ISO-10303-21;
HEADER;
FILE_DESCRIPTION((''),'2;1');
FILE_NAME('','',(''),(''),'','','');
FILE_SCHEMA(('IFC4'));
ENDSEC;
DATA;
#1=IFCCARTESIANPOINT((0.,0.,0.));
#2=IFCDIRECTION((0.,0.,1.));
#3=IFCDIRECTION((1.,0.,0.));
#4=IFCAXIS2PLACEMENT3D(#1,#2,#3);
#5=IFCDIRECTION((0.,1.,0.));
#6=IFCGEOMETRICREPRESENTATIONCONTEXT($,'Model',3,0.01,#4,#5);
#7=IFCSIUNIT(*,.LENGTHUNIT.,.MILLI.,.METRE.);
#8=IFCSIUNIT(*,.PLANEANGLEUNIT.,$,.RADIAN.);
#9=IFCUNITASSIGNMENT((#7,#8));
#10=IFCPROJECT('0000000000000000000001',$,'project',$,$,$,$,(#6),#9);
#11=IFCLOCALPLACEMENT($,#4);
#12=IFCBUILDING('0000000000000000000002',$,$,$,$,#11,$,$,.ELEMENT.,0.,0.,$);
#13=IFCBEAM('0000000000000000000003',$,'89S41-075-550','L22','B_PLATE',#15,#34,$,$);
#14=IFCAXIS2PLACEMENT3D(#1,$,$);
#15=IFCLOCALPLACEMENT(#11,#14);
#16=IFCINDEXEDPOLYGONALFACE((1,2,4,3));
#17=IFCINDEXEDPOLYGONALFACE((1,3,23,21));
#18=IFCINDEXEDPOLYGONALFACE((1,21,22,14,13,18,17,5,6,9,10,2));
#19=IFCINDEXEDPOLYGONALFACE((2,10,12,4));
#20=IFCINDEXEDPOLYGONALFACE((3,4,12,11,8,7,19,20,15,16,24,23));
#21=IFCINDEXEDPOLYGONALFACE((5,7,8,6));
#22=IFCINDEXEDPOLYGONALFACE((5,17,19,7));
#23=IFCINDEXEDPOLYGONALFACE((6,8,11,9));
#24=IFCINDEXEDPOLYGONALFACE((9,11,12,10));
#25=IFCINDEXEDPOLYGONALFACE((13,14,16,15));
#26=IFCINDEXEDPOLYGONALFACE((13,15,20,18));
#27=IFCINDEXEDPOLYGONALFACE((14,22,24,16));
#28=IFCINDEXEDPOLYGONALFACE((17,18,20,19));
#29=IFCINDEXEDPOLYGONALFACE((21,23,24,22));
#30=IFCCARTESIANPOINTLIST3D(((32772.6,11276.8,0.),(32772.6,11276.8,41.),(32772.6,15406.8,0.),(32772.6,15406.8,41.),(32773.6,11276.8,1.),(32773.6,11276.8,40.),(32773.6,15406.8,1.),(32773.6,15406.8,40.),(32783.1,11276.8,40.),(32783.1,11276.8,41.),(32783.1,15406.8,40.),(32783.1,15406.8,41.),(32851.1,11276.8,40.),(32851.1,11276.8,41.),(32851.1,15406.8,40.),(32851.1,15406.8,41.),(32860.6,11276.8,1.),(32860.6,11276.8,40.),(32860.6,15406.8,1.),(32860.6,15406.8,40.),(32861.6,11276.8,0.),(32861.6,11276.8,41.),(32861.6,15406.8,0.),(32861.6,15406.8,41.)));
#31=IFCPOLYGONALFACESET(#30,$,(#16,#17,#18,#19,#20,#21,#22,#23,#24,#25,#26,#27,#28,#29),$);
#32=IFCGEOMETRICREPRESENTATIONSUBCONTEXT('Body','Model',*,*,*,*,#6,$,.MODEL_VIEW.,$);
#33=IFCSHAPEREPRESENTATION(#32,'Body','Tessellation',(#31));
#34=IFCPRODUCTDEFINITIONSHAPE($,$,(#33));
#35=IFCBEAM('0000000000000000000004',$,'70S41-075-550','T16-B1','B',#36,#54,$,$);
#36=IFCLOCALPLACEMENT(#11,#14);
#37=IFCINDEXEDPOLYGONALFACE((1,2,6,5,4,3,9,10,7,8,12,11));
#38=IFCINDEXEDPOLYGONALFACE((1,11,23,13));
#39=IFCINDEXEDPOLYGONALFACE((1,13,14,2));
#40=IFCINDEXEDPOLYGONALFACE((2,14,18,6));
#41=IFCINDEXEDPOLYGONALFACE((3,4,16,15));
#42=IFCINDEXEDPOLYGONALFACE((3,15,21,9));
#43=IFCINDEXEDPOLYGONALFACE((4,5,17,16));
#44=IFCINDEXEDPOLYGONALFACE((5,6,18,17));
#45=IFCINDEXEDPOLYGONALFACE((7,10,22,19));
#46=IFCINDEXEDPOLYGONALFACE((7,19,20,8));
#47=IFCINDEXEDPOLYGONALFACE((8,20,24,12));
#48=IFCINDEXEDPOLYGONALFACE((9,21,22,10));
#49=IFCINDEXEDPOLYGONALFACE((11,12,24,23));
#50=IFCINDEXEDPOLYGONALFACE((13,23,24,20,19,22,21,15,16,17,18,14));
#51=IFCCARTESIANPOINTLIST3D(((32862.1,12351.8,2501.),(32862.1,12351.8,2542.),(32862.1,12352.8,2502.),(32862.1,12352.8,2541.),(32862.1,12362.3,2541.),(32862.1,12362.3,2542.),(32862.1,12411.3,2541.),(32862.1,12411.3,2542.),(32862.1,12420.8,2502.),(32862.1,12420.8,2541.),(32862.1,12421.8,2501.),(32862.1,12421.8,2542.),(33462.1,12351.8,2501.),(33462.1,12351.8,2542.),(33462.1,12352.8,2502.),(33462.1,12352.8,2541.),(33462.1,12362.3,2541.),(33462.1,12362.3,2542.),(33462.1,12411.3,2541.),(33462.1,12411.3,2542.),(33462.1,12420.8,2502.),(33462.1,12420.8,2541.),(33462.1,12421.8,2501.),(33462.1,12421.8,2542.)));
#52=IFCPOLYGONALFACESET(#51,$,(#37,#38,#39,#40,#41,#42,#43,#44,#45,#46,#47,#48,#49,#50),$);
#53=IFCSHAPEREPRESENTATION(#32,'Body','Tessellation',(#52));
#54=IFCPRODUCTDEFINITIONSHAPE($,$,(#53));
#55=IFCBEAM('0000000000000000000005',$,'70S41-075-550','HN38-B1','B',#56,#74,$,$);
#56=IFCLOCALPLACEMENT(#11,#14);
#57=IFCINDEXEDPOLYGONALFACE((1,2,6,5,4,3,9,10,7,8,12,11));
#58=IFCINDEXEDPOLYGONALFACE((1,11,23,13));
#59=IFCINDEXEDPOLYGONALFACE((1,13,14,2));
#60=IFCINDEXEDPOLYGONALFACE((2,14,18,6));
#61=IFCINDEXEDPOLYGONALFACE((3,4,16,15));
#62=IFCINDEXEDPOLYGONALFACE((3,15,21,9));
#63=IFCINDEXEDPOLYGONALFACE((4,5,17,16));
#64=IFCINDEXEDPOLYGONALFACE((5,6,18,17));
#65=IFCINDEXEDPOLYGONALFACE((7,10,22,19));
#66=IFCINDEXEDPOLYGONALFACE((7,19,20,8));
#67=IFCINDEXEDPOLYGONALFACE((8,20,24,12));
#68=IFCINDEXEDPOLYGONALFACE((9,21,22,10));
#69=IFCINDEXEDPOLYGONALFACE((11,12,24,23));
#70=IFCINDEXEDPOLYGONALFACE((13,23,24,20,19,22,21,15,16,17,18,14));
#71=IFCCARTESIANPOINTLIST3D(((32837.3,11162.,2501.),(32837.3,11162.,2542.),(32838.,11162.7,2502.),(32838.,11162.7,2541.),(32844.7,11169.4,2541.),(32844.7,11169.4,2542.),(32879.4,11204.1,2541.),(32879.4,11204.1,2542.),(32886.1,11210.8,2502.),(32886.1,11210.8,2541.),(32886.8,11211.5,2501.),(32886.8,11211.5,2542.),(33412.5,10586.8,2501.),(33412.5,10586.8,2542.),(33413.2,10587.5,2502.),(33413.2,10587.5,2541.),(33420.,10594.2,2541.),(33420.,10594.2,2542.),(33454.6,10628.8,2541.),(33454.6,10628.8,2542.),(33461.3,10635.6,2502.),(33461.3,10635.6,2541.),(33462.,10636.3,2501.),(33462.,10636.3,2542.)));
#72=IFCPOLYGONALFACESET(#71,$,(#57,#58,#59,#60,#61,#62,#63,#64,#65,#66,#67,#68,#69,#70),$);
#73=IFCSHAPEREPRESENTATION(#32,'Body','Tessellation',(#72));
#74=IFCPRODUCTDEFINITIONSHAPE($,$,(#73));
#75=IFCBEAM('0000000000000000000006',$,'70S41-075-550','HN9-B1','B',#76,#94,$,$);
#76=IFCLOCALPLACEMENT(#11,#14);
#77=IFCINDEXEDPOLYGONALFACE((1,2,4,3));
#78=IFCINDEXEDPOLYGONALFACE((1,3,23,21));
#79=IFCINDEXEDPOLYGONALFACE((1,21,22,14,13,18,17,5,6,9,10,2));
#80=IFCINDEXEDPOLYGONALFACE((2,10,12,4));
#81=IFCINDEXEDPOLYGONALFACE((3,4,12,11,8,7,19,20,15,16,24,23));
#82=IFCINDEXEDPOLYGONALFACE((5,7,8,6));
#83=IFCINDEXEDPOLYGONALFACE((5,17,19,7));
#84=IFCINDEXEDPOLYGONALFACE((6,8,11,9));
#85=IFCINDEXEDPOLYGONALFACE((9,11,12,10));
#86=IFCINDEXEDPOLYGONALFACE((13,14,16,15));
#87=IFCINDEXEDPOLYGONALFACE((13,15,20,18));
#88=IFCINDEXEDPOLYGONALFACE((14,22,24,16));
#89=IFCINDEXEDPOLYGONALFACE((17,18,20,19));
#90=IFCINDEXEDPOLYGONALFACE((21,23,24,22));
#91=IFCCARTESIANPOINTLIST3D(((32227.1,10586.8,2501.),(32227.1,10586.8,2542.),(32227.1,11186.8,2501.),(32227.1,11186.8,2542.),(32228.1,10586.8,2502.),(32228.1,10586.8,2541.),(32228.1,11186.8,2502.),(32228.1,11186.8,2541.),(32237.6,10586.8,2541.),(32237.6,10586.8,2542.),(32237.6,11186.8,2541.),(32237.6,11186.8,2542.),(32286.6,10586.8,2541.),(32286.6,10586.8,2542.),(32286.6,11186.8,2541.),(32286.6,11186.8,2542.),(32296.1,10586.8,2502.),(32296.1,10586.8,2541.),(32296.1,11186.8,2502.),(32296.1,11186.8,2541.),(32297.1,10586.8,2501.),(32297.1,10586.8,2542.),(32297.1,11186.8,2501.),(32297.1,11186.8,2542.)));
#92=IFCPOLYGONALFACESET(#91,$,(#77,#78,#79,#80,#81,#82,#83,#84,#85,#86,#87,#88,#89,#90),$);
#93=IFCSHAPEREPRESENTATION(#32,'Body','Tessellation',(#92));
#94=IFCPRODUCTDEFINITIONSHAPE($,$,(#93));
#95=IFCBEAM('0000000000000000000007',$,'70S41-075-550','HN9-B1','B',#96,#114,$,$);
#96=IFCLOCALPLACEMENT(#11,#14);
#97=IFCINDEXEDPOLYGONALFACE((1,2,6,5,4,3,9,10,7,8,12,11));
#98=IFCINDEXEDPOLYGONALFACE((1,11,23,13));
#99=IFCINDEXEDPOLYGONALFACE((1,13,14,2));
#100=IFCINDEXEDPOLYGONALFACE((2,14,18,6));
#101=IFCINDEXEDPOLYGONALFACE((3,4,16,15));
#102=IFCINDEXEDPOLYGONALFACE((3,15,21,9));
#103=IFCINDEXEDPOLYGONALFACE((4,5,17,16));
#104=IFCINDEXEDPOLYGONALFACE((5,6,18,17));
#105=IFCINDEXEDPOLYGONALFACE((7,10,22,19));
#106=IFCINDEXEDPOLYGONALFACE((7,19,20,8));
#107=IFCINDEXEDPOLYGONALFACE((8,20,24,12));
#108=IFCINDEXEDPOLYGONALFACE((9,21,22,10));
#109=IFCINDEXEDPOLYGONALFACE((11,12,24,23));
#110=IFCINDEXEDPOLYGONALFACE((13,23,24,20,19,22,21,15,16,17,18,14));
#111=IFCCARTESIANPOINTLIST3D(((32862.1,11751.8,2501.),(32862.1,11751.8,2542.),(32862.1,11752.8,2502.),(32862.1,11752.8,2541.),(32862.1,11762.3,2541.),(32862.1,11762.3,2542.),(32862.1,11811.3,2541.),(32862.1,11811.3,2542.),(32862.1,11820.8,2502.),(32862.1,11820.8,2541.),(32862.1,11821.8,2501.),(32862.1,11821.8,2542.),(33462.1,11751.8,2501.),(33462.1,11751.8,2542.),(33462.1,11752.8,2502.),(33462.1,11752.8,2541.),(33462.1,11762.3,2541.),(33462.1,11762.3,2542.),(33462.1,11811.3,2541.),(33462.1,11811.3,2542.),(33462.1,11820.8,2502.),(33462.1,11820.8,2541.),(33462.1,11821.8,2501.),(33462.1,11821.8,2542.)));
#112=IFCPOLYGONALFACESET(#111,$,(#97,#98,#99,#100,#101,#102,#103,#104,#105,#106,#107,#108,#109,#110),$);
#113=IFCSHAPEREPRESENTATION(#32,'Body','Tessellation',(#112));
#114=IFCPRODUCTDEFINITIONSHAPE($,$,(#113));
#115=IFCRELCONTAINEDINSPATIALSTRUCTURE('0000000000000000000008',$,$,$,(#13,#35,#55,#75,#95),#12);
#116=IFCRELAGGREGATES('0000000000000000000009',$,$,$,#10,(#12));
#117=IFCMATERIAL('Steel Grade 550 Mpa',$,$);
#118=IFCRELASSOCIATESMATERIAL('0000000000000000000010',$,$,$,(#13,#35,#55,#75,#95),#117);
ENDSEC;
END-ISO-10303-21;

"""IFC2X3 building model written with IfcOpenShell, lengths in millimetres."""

from ifc_helpers import new_model, si_unit, direction, frame, origin, origin_with_axes, origin_2d_with_axis, place, context, subcontext, project, spatial, c_section, extrude, source, transform, mapped, material, element, save


model = new_model("IFC2X3")

# Units and contexts
model_context = context("Model", 3, precision=0.01, world=origin_with_axes(), true_north=direction((0.0, 1.0, 0.0)))
body_context = subcontext(model_context, "Body", "Model", "MODEL_VIEW")
ifc_project = project(units=[si_unit("LENGTHUNIT", "METRE", prefix="MILLI"), si_unit("PLANEANGLEUNIT", "RADIAN")], contexts=[model_context])

# Building
building_placement = place(None, origin_with_axes())
building = spatial("IfcBuilding", under=ifc_project, at=building_placement, CompositionType="ELEMENT", ElevationOfRefHeight=0.0, ElevationOfTerrain=0.0)

# Shared definitions
ifc_material = material(Name="Steel Grade 550 Mpa")

# Beams
shared_shape_1 = source(origin(), body_context, "Body", "SweptSolid", [
    extrude(c_section(Depth=89.0, Width=41.0, WallThickness=1.0, Girth=10.5, at=origin_2d_with_axis()), origin_with_axes(), (0.0, 0.0, 1.0), 4130.0),
])
beam_1_placement = place(None, frame((32817.1, 11276.8, 20.5), z_axis=(0.0, 1.0, 0.0), x_axis=(0.0, 0.0, 1.0)))
element("IfcBeam", 1, at=beam_1_placement, inside=building, material=ifc_material, Name="89S41-075-550", Description="L22", ObjectType="B_PLATE", context=body_context, shape_type="MappedRepresentation", body=[
    mapped(shared_shape_1, transform((0.0, 0.0, 0.0), scale=1.0)),
])
shared_shape_2 = source(origin(), body_context, "Body", "SweptSolid", [
    extrude(c_section(Depth=70.0, Width=41.0, WallThickness=1.0, Girth=10.5, at=origin_2d_with_axis()), origin_with_axes(), (0.0, 0.0, 1.0), 600.0),
])
beam_2_placement = place(None, frame((33462.1, 12386.8, 2521.5), z_axis=(-1.0, 0.0, 0.0), x_axis=(0.0, 0.0, 1.0)))
element("IfcBeam", 2, at=beam_2_placement, inside=building, material=ifc_material, Name="70S41-075-550", Description="T16-B1", ObjectType="B", context=body_context, shape_type="MappedRepresentation", body=[
    mapped(shared_shape_2, transform((0.0, 0.0, 0.0), scale=1.0)),
])
shared_shape_3 = source(origin(), body_context, "Body", "SweptSolid", [
    extrude(c_section(Depth=70.0, Width=41.0, WallThickness=1.0, Girth=10.5, at=origin_2d_with_axis()), origin_with_axes(), (0.0, 0.0, 1.0), 813.5),
])
beam_3_placement = place(None, frame((33437.3, 10611.5, 2521.5), z_axis=(-0.707107, 0.707107, 0.0), x_axis=(0.0, 0.0, 1.0)))
element("IfcBeam", 3, at=beam_3_placement, inside=building, material=ifc_material, Name="70S41-075-550", Description="HN38-B1", ObjectType="B", context=body_context, shape_type="MappedRepresentation", body=[
    mapped(shared_shape_3, transform((0.0, 0.0, 0.0), scale=1.0)),
])
shared_shape_4 = source(origin(), body_context, "Body", "SweptSolid", [
    extrude(c_section(Depth=70.0, Width=41.0, WallThickness=1.0, Girth=10.5, at=origin_2d_with_axis()), origin_with_axes(), (0.0, 0.0, 1.0), 600.0),
])
beam_4_placement = place(None, frame((32262.1, 10586.8, 2521.5), z_axis=(0.0, 1.0, 0.0), x_axis=(0.0, 0.0, 1.0)))
element("IfcBeam", 4, at=beam_4_placement, inside=building, material=ifc_material, Name="70S41-075-550", Description="HN9-B1", ObjectType="B", context=body_context, shape_type="MappedRepresentation", body=[
    mapped(shared_shape_4, transform((0.0, 0.0, 0.0), scale=1.0)),
])
shared_shape_5 = source(origin(), body_context, "Body", "SweptSolid", [
    extrude(c_section(Depth=70.0, Width=41.0, WallThickness=1.0, Girth=10.5, at=origin_2d_with_axis()), origin_with_axes(), (0.0, 0.0, 1.0), 600.0),
])
beam_5_placement = place(None, frame((33462.1, 11786.8, 2521.5), z_axis=(-1.0, 0.0, 0.0), x_axis=(0.0, 0.0, 1.0)))
element("IfcBeam", 5, at=beam_5_placement, inside=building, material=ifc_material, Name="70S41-075-550", Description="HN9-B1", ObjectType="B", context=body_context, shape_type="MappedRepresentation", body=[
    mapped(shared_shape_5, transform((0.0, 0.0, 0.0), scale=1.0)),
])

save(model, "model.ifc")
